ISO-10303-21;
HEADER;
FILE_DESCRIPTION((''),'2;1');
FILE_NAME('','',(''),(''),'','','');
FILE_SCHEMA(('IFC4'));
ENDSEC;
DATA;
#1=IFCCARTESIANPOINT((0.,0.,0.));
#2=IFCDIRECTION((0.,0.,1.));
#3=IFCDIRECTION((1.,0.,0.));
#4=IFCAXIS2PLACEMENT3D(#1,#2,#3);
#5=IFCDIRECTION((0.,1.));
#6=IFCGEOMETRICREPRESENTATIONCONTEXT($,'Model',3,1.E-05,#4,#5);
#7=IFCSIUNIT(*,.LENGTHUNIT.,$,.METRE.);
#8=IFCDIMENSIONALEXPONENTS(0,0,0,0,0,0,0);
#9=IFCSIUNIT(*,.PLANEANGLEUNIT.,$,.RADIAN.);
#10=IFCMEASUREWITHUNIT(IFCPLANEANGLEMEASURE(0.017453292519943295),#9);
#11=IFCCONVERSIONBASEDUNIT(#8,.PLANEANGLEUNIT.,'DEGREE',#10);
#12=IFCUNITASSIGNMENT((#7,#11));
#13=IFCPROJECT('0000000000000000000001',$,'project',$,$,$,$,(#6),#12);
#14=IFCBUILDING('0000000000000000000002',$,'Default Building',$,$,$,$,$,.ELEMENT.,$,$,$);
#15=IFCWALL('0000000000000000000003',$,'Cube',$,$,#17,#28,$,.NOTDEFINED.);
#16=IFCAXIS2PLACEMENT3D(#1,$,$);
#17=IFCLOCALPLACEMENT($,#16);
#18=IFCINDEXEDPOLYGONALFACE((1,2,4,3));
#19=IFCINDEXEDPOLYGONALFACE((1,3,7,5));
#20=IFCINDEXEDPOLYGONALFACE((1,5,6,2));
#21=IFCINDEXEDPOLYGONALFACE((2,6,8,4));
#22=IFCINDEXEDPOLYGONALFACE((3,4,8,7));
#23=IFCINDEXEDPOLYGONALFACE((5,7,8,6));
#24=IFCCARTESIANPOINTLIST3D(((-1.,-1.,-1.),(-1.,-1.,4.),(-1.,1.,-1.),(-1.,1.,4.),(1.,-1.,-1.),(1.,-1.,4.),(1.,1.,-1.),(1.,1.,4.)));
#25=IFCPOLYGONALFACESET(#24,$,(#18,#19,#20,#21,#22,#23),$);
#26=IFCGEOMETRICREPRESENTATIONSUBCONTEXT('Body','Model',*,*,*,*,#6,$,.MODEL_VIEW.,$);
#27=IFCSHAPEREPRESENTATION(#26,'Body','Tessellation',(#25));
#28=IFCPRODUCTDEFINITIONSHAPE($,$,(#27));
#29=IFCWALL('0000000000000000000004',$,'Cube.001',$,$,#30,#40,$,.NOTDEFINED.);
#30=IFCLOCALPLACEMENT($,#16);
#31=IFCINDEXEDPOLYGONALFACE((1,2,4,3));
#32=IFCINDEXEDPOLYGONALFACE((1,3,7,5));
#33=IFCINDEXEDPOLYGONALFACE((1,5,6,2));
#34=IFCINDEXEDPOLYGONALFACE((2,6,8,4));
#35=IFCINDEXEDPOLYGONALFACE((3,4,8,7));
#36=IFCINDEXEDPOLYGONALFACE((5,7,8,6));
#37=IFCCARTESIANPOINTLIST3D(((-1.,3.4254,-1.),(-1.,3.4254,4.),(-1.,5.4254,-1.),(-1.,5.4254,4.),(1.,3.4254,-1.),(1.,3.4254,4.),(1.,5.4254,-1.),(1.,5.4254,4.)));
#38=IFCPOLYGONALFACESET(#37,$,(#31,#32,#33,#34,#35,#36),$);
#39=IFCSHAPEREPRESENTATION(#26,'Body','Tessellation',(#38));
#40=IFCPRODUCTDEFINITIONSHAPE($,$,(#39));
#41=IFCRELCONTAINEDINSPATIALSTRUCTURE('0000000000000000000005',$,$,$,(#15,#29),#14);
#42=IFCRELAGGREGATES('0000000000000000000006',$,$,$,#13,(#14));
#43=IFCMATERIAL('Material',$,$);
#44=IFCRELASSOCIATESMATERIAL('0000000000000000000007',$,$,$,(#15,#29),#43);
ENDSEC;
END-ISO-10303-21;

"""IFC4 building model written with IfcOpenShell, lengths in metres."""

from ifc_helpers import new_model, entity, si_unit, converted_unit, direction, frame, frame_2d, origin_with_axes, place, context, subcontext, project, spatial, rectangle, extrude, source, transform, mapped, material, element, save


model = new_model("IFC4")

# Units and contexts
model_context = context("Model", 3, precision=1e-05, world=origin_with_axes(), true_north=direction((0.0, 1.0)))
body_context = subcontext(model_context, "Body", "Model", "MODEL_VIEW")
ifc_project = project(units=[si_unit("LENGTHUNIT", "METRE"), converted_unit("PLANEANGLEUNIT", "DEGREE", entity("IfcPlaneAngleMeasure", 0.017453292519943295), si_unit("PLANEANGLEUNIT", "RADIAN"), dimensions=[0, 0, 0, 0, 0, 0, 0])], contexts=[model_context])

# Building
building = spatial("IfcBuilding", under=ifc_project, Name="Default Building", CompositionType="ELEMENT")

# Walls
ifc_material = material(Name="Material")
shared_shape = source(origin_with_axes(), body_context, "Body", "SweptSolid", [
    extrude(rectangle(XDim=2.0, YDim=2.0, at=frame_2d((0.0, 0.0), x_axis=(0.0, 1.0))), frame((0.0, 0.0, -1.0), z_axis=(0.0, 0.0, 1.0), x_axis=(1.0, 0.0, 0.0)), (0.0, 0.0, 1.0), 5.0),
])
placement = place(None, origin_with_axes())
element("IfcWall", 1, at=placement, inside=building, material=ifc_material, Name="Cube", PredefinedType="NOTDEFINED", context=body_context, shape_type="MappedRepresentation", body=[
    mapped(shared_shape, transform((0.0, 0.0, 0.0), x_axis=(1.0, 0.0, 0.0), y_axis=(0.0, 1.0, 0.0), z_axis=(0.0, 0.0, 1.0), scale=1.0)),
])
element("IfcWall", 2, at=placement, inside=building, material=ifc_material, Name="Cube.001", PredefinedType="NOTDEFINED", context=body_context, shape_type="MappedRepresentation", body=[
    mapped(shared_shape, transform((0.0, 4.4254, 0.0), x_axis=(1.0, 0.0, 0.0), y_axis=(0.0, 1.0, 0.0), z_axis=(0.0, 0.0, 1.0), scale=1.0)),
])

save(model, "model.ifc")
